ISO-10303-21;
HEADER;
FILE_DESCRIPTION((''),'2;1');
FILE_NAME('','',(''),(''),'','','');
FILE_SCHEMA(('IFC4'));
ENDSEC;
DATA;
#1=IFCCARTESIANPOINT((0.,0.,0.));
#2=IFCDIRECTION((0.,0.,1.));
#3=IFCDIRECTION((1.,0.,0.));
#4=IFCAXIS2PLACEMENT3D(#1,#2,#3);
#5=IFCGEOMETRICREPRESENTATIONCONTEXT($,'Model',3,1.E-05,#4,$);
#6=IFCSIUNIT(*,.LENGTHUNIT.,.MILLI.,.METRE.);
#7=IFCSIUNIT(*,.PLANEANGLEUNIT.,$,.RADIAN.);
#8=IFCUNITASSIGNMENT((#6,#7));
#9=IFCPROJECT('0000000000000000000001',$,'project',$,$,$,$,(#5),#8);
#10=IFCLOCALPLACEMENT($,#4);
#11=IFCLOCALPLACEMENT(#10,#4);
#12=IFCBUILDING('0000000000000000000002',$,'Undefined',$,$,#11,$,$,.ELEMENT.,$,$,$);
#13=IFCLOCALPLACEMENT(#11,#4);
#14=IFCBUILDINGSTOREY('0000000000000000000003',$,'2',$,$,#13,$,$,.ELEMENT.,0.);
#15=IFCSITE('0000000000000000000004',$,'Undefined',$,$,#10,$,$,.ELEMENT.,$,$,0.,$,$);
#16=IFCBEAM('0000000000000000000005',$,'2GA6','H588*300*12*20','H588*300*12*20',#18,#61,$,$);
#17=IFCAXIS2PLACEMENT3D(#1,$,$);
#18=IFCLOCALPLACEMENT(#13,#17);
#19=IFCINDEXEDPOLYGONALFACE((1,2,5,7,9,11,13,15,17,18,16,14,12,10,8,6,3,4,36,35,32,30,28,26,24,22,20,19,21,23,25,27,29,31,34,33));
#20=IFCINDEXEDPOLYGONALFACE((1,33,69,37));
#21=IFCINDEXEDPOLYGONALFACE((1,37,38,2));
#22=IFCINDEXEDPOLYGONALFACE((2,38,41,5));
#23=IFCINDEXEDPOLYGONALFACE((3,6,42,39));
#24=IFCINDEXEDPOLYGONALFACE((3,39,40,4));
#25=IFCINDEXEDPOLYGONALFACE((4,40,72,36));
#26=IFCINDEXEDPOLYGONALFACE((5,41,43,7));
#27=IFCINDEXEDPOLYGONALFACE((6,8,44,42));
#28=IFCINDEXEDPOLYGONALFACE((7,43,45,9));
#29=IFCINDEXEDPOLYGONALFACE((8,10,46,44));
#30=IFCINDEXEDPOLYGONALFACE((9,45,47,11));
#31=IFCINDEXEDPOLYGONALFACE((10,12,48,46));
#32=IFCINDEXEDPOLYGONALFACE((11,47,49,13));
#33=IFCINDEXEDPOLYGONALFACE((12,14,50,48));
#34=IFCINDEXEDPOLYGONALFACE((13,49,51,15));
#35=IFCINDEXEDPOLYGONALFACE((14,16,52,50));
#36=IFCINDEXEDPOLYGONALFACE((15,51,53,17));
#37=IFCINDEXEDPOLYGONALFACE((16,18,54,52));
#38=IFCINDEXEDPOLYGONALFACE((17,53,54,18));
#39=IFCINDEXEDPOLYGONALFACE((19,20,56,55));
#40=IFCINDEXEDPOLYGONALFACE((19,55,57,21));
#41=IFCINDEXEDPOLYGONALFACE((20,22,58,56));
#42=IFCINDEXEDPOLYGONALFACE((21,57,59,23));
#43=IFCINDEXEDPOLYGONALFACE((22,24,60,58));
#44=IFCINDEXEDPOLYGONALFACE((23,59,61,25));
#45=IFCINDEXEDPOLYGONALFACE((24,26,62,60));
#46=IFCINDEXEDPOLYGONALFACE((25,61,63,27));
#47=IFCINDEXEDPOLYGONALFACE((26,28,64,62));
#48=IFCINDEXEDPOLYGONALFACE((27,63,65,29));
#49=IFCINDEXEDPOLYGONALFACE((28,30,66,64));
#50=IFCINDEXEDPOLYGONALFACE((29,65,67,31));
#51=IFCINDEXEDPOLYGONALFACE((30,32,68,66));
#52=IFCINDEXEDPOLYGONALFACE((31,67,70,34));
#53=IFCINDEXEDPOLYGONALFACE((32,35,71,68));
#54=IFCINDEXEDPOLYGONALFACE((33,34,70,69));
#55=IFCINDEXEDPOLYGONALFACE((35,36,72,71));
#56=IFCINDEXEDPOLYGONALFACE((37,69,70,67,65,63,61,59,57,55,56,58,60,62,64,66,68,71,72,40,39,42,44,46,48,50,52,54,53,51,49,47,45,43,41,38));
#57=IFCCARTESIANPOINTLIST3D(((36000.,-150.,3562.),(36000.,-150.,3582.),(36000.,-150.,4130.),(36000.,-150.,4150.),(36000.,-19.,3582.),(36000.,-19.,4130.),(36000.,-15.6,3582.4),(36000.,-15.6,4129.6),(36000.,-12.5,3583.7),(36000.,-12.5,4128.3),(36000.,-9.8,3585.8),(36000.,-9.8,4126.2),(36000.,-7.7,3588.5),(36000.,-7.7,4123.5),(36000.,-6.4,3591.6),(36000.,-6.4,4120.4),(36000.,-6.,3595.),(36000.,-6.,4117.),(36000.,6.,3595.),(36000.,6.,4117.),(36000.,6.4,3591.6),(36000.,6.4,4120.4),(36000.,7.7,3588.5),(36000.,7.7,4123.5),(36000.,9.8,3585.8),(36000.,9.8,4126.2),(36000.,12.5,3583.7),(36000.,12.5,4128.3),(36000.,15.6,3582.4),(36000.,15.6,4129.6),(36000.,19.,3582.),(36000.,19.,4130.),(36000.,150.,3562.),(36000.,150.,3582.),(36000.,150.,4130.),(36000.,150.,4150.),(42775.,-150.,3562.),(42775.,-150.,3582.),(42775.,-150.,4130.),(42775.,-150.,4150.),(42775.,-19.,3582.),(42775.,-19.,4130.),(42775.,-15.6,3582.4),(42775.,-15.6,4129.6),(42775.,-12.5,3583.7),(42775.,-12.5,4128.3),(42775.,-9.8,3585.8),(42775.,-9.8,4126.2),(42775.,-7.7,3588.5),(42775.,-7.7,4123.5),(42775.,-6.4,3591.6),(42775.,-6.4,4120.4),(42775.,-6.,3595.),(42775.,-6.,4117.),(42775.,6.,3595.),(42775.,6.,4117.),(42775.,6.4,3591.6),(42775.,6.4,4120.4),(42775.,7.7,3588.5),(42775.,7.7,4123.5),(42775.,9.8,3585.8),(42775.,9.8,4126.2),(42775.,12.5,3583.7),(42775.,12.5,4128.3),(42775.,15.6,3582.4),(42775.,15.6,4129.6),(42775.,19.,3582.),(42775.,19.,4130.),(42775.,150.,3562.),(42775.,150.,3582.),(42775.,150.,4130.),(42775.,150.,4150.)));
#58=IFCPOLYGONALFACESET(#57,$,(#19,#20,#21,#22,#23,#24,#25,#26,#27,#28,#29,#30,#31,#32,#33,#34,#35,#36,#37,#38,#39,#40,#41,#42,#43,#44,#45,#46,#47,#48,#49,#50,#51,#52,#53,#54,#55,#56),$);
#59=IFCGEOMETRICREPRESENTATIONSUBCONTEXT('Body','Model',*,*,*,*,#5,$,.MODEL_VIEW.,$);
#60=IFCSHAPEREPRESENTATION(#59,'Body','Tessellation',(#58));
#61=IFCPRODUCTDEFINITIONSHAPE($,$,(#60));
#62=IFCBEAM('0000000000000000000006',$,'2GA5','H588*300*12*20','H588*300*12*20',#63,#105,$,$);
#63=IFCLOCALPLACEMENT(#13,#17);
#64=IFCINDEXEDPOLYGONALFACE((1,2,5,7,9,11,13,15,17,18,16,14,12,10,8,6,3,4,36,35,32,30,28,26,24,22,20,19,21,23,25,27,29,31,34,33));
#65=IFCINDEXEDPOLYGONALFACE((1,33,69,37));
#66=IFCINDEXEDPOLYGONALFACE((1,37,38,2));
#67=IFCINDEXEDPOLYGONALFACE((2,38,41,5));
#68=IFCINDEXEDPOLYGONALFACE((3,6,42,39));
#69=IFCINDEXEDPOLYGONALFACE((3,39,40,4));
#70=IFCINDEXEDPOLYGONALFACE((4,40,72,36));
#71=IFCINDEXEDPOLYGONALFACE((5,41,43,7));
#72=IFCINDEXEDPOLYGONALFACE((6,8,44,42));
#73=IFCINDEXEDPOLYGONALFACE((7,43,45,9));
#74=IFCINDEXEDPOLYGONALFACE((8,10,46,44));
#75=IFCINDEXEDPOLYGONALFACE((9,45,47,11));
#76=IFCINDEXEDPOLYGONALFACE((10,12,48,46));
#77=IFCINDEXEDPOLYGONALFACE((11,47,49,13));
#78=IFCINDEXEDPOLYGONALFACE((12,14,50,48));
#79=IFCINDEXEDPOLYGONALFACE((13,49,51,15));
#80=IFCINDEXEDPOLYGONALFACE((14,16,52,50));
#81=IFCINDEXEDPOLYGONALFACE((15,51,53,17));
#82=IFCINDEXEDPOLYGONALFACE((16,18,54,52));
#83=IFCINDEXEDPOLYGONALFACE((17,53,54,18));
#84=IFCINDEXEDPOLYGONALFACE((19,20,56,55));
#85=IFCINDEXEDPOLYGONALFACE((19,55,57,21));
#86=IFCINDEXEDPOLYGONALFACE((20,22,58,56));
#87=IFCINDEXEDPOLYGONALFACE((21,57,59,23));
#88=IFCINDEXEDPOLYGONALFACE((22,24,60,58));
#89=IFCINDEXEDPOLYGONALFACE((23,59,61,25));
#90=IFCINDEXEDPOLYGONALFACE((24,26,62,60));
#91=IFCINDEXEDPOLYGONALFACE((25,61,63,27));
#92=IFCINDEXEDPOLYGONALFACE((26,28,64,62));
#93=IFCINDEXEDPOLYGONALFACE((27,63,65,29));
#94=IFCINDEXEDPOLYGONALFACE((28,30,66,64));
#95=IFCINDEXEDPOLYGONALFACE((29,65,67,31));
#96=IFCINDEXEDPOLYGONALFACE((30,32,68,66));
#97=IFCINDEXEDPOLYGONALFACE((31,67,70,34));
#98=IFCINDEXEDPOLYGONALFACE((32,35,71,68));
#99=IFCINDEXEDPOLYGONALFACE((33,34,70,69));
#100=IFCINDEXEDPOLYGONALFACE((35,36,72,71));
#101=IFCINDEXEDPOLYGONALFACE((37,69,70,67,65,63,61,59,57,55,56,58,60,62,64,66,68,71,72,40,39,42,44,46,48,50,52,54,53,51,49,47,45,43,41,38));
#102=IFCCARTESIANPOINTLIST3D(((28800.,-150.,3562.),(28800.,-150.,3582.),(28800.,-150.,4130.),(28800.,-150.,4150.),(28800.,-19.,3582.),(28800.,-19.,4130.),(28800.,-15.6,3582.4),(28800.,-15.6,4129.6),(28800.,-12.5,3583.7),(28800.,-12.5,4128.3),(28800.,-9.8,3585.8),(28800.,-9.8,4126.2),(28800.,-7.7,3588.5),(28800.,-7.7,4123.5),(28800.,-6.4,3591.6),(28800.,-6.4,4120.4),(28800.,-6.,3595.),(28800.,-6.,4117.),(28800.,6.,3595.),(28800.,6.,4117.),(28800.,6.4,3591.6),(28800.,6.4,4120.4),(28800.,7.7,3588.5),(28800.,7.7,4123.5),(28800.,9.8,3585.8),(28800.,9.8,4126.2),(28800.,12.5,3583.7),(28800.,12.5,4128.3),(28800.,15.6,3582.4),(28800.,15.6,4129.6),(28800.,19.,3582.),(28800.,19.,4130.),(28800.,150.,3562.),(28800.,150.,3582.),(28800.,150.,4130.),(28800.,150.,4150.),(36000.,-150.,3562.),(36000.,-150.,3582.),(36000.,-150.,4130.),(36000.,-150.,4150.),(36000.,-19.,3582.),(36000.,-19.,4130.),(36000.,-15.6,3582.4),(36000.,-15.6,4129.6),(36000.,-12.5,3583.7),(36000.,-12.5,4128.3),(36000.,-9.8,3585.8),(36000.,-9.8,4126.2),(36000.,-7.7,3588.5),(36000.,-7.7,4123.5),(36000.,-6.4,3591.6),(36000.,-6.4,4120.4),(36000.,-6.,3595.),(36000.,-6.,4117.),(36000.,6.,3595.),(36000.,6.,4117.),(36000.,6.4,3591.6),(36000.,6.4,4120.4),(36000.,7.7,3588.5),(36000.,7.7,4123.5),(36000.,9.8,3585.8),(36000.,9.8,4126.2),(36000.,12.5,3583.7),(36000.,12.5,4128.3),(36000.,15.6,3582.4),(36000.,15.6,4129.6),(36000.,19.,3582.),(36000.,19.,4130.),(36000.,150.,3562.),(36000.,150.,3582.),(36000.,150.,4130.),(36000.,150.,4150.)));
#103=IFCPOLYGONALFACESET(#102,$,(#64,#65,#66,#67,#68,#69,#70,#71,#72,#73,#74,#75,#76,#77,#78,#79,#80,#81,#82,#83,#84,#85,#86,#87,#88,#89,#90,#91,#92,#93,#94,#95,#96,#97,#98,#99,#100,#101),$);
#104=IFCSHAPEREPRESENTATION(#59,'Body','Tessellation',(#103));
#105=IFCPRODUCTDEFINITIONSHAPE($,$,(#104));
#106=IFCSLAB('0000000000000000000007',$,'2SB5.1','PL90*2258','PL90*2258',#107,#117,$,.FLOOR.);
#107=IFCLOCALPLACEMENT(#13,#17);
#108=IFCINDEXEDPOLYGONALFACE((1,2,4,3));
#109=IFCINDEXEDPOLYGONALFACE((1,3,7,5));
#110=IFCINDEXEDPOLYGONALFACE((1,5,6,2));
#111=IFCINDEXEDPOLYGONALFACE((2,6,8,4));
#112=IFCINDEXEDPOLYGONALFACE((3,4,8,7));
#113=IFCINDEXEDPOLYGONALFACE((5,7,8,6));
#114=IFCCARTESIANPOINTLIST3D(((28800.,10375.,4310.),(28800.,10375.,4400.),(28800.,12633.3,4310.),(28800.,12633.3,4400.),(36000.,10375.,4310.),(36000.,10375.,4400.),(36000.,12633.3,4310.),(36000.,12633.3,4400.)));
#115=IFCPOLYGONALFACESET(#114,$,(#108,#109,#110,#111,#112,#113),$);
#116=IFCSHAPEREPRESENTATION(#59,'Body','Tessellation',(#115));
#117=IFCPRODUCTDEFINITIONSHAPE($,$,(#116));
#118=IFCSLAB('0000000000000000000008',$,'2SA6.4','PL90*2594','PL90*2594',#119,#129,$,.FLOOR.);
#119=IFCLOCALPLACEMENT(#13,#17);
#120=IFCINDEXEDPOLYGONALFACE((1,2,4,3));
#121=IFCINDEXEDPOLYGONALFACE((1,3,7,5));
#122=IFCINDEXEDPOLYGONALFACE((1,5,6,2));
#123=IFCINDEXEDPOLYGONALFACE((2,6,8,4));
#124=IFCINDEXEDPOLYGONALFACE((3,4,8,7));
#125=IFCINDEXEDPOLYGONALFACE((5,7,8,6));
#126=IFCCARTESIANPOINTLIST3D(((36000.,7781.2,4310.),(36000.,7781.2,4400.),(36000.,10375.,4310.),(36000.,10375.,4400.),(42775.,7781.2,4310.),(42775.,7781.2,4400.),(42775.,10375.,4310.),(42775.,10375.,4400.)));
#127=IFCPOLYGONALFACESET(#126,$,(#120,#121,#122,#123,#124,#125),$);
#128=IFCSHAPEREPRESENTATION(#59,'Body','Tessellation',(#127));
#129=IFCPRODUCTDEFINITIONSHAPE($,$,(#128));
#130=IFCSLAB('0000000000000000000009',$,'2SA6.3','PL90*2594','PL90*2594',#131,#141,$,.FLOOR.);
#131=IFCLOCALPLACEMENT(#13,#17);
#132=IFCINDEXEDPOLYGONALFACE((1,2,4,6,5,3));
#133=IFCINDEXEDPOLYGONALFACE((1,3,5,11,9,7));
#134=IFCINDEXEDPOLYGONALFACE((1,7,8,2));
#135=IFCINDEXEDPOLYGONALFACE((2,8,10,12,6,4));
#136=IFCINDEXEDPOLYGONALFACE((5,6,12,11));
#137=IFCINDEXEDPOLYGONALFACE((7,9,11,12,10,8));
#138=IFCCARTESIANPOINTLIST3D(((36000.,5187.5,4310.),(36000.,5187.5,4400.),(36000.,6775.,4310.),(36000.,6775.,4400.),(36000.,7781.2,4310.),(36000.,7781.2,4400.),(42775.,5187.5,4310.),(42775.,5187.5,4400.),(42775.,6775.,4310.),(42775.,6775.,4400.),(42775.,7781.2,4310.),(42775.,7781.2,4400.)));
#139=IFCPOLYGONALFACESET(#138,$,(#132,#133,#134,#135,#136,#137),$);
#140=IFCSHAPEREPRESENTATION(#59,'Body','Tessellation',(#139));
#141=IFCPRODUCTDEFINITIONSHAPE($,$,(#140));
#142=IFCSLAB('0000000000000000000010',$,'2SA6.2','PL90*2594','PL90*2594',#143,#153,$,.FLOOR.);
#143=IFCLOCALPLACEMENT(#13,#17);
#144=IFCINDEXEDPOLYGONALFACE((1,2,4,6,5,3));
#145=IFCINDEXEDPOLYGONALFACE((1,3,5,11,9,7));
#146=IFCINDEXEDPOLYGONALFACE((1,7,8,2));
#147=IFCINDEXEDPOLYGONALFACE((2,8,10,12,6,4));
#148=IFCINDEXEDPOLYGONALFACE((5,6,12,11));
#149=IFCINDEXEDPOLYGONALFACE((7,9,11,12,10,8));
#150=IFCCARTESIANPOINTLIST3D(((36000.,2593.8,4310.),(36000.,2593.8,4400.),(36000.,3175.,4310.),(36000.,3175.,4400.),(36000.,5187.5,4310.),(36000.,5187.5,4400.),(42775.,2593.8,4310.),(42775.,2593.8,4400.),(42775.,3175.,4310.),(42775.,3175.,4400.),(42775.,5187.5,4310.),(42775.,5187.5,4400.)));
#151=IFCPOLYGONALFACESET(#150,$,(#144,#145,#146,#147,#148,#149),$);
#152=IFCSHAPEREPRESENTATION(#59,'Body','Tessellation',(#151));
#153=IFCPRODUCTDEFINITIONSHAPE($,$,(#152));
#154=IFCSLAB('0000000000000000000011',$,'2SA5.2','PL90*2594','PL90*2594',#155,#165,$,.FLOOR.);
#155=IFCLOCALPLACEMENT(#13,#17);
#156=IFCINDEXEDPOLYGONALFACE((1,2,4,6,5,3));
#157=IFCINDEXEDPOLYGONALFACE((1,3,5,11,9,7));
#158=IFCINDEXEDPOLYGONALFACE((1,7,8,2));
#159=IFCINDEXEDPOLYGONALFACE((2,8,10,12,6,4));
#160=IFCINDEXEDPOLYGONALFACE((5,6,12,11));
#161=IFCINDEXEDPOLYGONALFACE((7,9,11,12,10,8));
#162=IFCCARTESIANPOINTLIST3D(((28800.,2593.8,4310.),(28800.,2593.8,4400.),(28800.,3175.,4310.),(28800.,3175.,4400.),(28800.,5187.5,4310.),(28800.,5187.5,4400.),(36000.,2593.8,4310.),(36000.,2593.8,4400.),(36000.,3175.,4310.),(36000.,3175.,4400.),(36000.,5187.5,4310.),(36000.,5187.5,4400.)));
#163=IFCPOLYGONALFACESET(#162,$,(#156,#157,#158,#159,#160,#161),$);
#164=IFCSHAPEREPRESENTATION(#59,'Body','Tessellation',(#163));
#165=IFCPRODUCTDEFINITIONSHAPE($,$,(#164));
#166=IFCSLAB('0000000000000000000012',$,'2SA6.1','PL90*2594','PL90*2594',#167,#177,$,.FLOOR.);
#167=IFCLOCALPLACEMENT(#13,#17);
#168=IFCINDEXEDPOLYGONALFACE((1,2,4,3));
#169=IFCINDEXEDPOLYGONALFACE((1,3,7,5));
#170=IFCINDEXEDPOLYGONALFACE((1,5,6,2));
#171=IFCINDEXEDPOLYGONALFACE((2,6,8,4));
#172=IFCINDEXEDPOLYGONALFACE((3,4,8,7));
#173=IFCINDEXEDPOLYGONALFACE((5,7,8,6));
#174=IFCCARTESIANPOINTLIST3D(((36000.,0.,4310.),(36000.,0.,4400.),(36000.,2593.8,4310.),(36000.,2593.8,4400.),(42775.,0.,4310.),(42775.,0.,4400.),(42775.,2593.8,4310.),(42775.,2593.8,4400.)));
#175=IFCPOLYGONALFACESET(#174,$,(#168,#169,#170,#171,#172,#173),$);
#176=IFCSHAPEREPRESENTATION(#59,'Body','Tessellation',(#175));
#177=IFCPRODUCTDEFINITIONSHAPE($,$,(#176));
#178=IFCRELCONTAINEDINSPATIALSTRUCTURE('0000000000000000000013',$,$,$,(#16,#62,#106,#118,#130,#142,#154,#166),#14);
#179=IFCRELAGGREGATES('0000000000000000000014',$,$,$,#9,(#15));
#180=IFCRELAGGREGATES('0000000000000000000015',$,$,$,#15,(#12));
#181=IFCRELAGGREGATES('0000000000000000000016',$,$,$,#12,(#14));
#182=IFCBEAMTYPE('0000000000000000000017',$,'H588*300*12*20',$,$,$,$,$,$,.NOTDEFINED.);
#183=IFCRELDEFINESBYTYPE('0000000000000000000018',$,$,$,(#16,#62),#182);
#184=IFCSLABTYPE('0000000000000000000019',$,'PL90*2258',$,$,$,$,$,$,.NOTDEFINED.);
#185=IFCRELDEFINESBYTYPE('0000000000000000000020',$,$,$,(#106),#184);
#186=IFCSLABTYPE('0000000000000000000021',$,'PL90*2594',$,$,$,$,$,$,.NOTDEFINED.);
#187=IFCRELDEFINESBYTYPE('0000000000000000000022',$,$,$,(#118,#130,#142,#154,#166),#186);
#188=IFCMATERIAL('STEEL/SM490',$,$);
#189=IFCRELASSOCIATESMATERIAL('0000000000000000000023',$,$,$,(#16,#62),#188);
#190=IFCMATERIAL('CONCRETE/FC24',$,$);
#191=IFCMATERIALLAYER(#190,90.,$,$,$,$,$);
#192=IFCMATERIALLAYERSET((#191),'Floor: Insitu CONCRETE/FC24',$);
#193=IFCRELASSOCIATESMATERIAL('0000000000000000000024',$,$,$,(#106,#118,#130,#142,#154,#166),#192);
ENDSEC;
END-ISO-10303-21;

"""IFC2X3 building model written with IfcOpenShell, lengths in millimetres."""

from ifc_helpers import new_model, si_unit, frame, origin_with_axes, origin_2d_with_axis, place, context, subcontext, project, spatial, polyline, i_section, outline, extrude, material, layer, layer_set, layer_usage, type_object, element, save


model = new_model("IFC2X3")

# Units and contexts
model_context = context("Model", 3, precision=1e-05, world=origin_with_axes())
body_context = subcontext(model_context, "Body", "Model", "MODEL_VIEW")
ifc_project = project(units=[si_unit("LENGTHUNIT", "METRE", prefix="MILLI"), si_unit("PLANEANGLEUNIT", "RADIAN")], contexts=[model_context])

# Site, building, storey
site_placement = place(None, origin_with_axes())
site = spatial("IfcSite", under=ifc_project, at=site_placement, Name="Undefined", CompositionType="ELEMENT", RefElevation=0.0)
building_placement = place(site_placement, origin_with_axes())
building = spatial("IfcBuilding", under=site, at=building_placement, Name="Undefined", CompositionType="ELEMENT")
storey_placement = place(building_placement, origin_with_axes())
storey = spatial("IfcBuildingStorey", under=building, at=storey_placement, Name="2", CompositionType="ELEMENT", Elevation=0.0)

# Beams
ifc_material_1 = material(Name="STEEL/SM490")
beam_type_1 = type_object("IfcBeamType", Name="H588*300*12*20", PredefinedType="NOTDEFINED")
beam_1_placement = place(storey_placement, frame((36000.0, 0.0, 3856.0), z_axis=(0.0, 0.0, 1.0), x_axis=(1.0, 0.0, 0.0)))
element("IfcBeam", 1, at=beam_1_placement, inside=storey, type_object=beam_type_1, material=ifc_material_1, Name="2GA6", Description="H588*300*12*20", ObjectType="H588*300*12*20", context=body_context, shape_type="SweptSolid", body=[
    extrude(i_section(OverallWidth=300.0, OverallDepth=588.0, WebThickness=12.0, FlangeThickness=20.0, FilletRadius=13.0, at=origin_2d_with_axis()), frame((6775.0, 0.0, 0.0), z_axis=(-1.0, 0.0, 0.0), x_axis=(0.0, -1.0, 0.0)), (0.0, 0.0, 1.0), 6775.0),
])
beam_2_placement = place(storey_placement, frame((28800.0, 0.0, 3856.0), z_axis=(0.0, 0.0, 1.0), x_axis=(1.0, 0.0, 0.0)))
element("IfcBeam", 2, at=beam_2_placement, inside=storey, type_object=beam_type_1, material=ifc_material_1, Name="2GA5", Description="H588*300*12*20", ObjectType="H588*300*12*20", context=body_context, shape_type="SweptSolid", body=[
    extrude(i_section(OverallWidth=300.0, OverallDepth=588.0, WebThickness=12.0, FlangeThickness=20.0, FilletRadius=13.0, at=origin_2d_with_axis()), frame((7200.0, 0.0, 0.0), z_axis=(-1.0, 0.0, 0.0), x_axis=(0.0, -1.0, 0.0)), (0.0, 0.0, 1.0), 7200.0),
])

# Slabs
ifc_material_2 = material(Name="CONCRETE/FC24")
ifc_layer = layer(ifc_material_2, 90.0)
ifc_layer_set = layer_set([ifc_layer], Name="Floor: Insitu CONCRETE/FC24")
ifc_layer_usage_1 = layer_usage(ifc_layer_set, "AXIS3", "POSITIVE", -45.0)
slab_type_1 = type_object("IfcSlabType", Name="PL90*2258", PredefinedType="NOTDEFINED")
slab_1_placement = place(storey_placement, frame((28800.0, 10375.0, 4355.0), z_axis=(0.0, 0.0, 1.0), x_axis=(1.0, 0.0, 0.0)))
element("IfcSlab", 3, at=slab_1_placement, inside=storey, type_object=slab_type_1, material=ifc_layer_usage_1, Name="2SB5.1", Description="PL90*2258", ObjectType="PL90*2258", PredefinedType="FLOOR", context=body_context, shape_type="SweptSolid", body=[
    extrude(outline(polyline([(0.0, 0.0), (7200.0, 0.0), (7200.0, 2258.3), (0.0, 2258.3), (0.0, 0.0)])), frame((0.0, 0.0, -45.0), z_axis=(0.0, 0.0, 1.0), x_axis=(1.0, 0.0, 0.0)), (0.0, 0.0, 1.0), 90.0),
])
ifc_layer_usage_2 = layer_usage(ifc_layer_set, "AXIS3", "POSITIVE", -45.0)
slab_type_2 = type_object("IfcSlabType", Name="PL90*2594", PredefinedType="NOTDEFINED")
slab_2_placement = place(storey_placement, frame((36000.0, 7781.2, 4355.0), z_axis=(0.0, 0.0, 1.0), x_axis=(1.0, 0.0, 0.0)))
element("IfcSlab", 4, at=slab_2_placement, inside=storey, type_object=slab_type_2, material=ifc_layer_usage_2, Name="2SA6.4", Description="PL90*2594", ObjectType="PL90*2594", PredefinedType="FLOOR", context=body_context, shape_type="SweptSolid", body=[
    extrude(outline(polyline([(0.0, 0.0), (6775.0, 0.0), (6775.0, 2593.8), (0.0, 2593.8), (0.0, 0.0)])), frame((0.0, 0.0, -45.0), z_axis=(0.0, 0.0, 1.0), x_axis=(1.0, 0.0, 0.0)), (0.0, 0.0, 1.0), 90.0),
])
ifc_layer_usage_3 = layer_usage(ifc_layer_set, "AXIS3", "POSITIVE", -45.0)
slab_3_placement = place(storey_placement, frame((36000.0, 5187.5, 4355.0), z_axis=(0.0, 0.0, 1.0), x_axis=(1.0, 0.0, 0.0)))
element("IfcSlab", 5, at=slab_3_placement, inside=storey, type_object=slab_type_2, material=ifc_layer_usage_3, Name="2SA6.3", Description="PL90*2594", ObjectType="PL90*2594", PredefinedType="FLOOR", context=body_context, shape_type="SweptSolid", body=[
    extrude(outline(polyline([(0.0, 0.0), (6775.0, 0.0), (6775.0, 1587.5), (6775.0, 2593.8), (0.0, 2593.8), (0.0, 1587.5), (0.0, 0.0)])), frame((0.0, 0.0, -45.0), z_axis=(0.0, 0.0, 1.0), x_axis=(1.0, 0.0, 0.0)), (0.0, 0.0, 1.0), 90.0),
])
ifc_layer_usage_4 = layer_usage(ifc_layer_set, "AXIS3", "POSITIVE", -45.0)
slab_4_placement = place(storey_placement, frame((36000.0, 2593.8, 4355.0), z_axis=(0.0, 0.0, 1.0), x_axis=(1.0, 0.0, 0.0)))
element("IfcSlab", 6, at=slab_4_placement, inside=storey, type_object=slab_type_2, material=ifc_layer_usage_4, Name="2SA6.2", Description="PL90*2594", ObjectType="PL90*2594", PredefinedType="FLOOR", context=body_context, shape_type="SweptSolid", body=[
    extrude(outline(polyline([(0.0, 0.0), (6775.0, 0.0), (6775.0, 581.2), (6775.0, 2593.8), (0.0, 2593.8), (0.0, 581.2), (0.0, 0.0)])), frame((0.0, 0.0, -45.0), z_axis=(0.0, 0.0, 1.0), x_axis=(1.0, 0.0, 0.0)), (0.0, 0.0, 1.0), 90.0),
])
ifc_layer_usage_5 = layer_usage(ifc_layer_set, "AXIS3", "POSITIVE", -45.0)
slab_5_placement = place(storey_placement, frame((28800.0, 2593.8, 4355.0), z_axis=(0.0, 0.0, 1.0), x_axis=(1.0, 0.0, 0.0)))
element("IfcSlab", 7, at=slab_5_placement, inside=storey, type_object=slab_type_2, material=ifc_layer_usage_5, Name="2SA5.2", Description="PL90*2594", ObjectType="PL90*2594", PredefinedType="FLOOR", context=body_context, shape_type="SweptSolid", body=[
    extrude(outline(polyline([(0.0, 0.0), (7200.0, 0.0), (7200.0, 581.2), (7200.0, 2593.8), (0.0, 2593.8), (0.0, 581.2), (0.0, 0.0)])), frame((0.0, 0.0, -45.0), z_axis=(0.0, 0.0, 1.0), x_axis=(1.0, 0.0, 0.0)), (0.0, 0.0, 1.0), 90.0),
])
ifc_layer_usage_6 = layer_usage(ifc_layer_set, "AXIS3", "POSITIVE", -45.0)
slab_6_placement = place(storey_placement, frame((36000.0, 0.0, 4355.0), z_axis=(0.0, 0.0, 1.0), x_axis=(1.0, 0.0, 0.0)))
element("IfcSlab", 8, at=slab_6_placement, inside=storey, type_object=slab_type_2, material=ifc_layer_usage_6, Name="2SA6.1", Description="PL90*2594", ObjectType="PL90*2594", PredefinedType="FLOOR", context=body_context, shape_type="SweptSolid", body=[
    extrude(outline(polyline([(0.0, 0.0), (6775.0, 0.0), (6775.0, 2593.8), (0.0, 2593.8), (0.0, 0.0)])), frame((0.0, 0.0, -45.0), z_axis=(0.0, 0.0, 1.0), x_axis=(1.0, 0.0, 0.0)), (0.0, 0.0, 1.0), 90.0),
])

save(model, "model.ifc")
